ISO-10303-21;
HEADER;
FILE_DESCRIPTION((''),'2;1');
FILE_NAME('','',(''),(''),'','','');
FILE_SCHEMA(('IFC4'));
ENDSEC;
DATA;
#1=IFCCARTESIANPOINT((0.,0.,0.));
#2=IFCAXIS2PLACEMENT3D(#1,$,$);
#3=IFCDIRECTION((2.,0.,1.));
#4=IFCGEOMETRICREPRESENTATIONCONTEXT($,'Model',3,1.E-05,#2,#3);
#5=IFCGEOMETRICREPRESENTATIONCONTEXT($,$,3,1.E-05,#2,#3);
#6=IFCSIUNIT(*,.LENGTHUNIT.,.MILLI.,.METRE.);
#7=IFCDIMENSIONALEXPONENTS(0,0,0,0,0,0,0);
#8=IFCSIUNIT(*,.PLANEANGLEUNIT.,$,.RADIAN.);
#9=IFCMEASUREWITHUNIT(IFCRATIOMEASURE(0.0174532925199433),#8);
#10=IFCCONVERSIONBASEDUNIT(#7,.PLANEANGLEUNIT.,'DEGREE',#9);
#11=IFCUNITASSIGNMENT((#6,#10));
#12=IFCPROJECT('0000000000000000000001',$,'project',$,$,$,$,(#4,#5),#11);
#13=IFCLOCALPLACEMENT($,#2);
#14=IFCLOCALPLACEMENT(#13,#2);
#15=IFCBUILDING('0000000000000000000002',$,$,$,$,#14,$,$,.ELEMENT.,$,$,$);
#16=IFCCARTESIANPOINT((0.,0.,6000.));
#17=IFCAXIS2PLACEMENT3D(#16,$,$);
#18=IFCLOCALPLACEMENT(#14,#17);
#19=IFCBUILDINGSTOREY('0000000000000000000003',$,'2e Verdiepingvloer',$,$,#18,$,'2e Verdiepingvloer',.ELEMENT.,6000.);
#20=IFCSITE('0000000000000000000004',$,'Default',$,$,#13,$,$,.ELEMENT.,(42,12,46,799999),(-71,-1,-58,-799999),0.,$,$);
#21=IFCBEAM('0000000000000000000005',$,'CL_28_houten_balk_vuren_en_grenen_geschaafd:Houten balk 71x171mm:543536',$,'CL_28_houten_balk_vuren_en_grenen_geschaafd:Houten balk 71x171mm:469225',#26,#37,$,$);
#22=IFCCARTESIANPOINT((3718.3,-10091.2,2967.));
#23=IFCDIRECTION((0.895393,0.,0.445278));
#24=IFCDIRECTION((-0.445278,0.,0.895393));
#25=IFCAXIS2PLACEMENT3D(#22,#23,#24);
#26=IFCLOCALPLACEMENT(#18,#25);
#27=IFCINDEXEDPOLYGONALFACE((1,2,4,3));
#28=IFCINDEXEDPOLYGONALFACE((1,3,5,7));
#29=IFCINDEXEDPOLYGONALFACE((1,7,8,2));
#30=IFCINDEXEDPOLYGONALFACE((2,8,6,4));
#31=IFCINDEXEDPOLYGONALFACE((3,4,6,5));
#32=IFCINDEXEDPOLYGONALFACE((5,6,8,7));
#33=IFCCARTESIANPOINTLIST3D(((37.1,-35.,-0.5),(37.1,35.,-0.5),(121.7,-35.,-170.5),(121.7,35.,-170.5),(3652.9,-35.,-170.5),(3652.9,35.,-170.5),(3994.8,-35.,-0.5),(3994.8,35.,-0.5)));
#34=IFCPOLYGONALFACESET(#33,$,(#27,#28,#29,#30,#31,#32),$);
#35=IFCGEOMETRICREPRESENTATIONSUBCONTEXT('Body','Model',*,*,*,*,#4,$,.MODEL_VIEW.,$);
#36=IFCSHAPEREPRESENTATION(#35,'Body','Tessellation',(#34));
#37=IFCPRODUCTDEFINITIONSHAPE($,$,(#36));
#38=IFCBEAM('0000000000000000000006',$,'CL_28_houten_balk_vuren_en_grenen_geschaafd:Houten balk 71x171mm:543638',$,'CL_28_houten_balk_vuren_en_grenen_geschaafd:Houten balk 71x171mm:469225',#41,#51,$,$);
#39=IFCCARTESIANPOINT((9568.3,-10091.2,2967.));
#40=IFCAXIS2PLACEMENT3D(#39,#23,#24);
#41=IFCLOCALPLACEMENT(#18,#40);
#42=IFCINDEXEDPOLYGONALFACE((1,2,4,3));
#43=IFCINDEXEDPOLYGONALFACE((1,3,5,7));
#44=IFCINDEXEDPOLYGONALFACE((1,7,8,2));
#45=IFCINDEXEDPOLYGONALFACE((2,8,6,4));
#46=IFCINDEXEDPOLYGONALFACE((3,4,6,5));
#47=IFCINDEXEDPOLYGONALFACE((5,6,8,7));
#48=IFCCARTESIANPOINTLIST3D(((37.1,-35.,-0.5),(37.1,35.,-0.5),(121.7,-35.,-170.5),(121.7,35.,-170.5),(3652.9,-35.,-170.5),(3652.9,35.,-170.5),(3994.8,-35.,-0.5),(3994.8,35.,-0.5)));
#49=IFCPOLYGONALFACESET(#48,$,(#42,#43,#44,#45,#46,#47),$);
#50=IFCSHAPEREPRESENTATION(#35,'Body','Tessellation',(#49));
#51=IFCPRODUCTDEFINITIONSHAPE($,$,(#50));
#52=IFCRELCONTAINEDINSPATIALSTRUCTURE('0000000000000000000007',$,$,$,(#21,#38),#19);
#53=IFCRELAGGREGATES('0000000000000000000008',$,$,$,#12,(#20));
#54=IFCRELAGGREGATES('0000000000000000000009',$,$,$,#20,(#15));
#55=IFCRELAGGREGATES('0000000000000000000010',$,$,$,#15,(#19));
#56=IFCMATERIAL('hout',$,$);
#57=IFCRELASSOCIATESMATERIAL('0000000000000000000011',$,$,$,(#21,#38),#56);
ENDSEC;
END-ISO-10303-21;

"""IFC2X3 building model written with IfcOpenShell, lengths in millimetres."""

from ifc_helpers import new_model, entity, si_unit, converted_unit, direction, frame, frame_2d, origin, place, context, subcontext, project, spatial, rectangle, extrude, clip, halfspace, material, element, save


model = new_model("IFC2X3")

# Units and contexts
model_context = context("Model", 3, precision=1e-05, world=origin(), true_north=direction((2.0, 0.0, 1.0)))
context_of_model = context(None, 3, precision=1e-05, world=origin(), true_north=direction((2.0, 0.0, 1.0)))
body_context = subcontext(model_context, "Body", "Model", "MODEL_VIEW")
ifc_project = project(units=[si_unit("LENGTHUNIT", "METRE", prefix="MILLI"), converted_unit("PLANEANGLEUNIT", "DEGREE", entity("IfcRatioMeasure", 0.0174532925199433), si_unit("PLANEANGLEUNIT", "RADIAN"), dimensions=[0, 0, 0, 0, 0, 0, 0])], contexts=[model_context, context_of_model])

# Site, building, storey
site_placement = place(None, origin())
site = spatial("IfcSite", under=ifc_project, at=site_placement, Name="Default", CompositionType="ELEMENT", RefLatitude=(42, 12, 46, 799999), RefLongitude=(-71, -1, -58, -799999), RefElevation=0.0)
building_placement = place(site_placement, origin())
building = spatial("IfcBuilding", under=site, at=building_placement, CompositionType="ELEMENT")
storey_placement = place(building_placement, frame((0.0, 0.0, 6000.0)))
storey = spatial("IfcBuildingStorey", under=building, at=storey_placement, Name="2e Verdiepingvloer", LongName="2e Verdiepingvloer", CompositionType="ELEMENT", Elevation=6000.0)

# Beams
ifc_material_1 = material(Name="hout")
beam_1_placement = place(storey_placement, frame((3718.3, -10091.2, 2967.0), z_axis=(0.895393, 0.0, 0.445278), x_axis=(-0.445278, 0.0, 0.895393)))
element("IfcBeam", 1, at=beam_1_placement, inside=storey, material=ifc_material_1, Name="CL_28_houten_balk_vuren_en_grenen_geschaafd:Houten balk 71x171mm:543536", ObjectType="CL_28_houten_balk_vuren_en_grenen_geschaafd:Houten balk 71x171mm:469225", context=body_context, shape_type="Clipping", body=[
    clip(clip(extrude(rectangle(XDim=170.0, YDim=70.0, at=frame_2d((0.0, 0.0), x_axis=(1.0, 0.0))), frame((37.1, 0.0, -85.5), z_axis=(1.0, 0.0, 0.0), x_axis=(0.0, 0.0, -1.0)), (0.0, 0.0, 1.0), 3957.7), halfspace(frame((3651.9, 0.0, -171.0), z_axis=(0.445278, 0.0, -0.895393), x_axis=(0.0, 1.0, 0.0)), False)), halfspace(frame((-9522.9, -1.8, 19223.4), z_axis=(-0.895393, 0.0, -0.445278), x_axis=(0.445278, 0.0, -0.895393)), False)),
])
beam_2_placement = place(storey_placement, frame((9568.3, -10091.2, 2967.0), z_axis=(0.895393, 0.0, 0.445278), x_axis=(-0.445278, 0.0, 0.895393)))
element("IfcBeam", 2, at=beam_2_placement, inside=storey, material=ifc_material_1, Name="CL_28_houten_balk_vuren_en_grenen_geschaafd:Houten balk 71x171mm:543638", ObjectType="CL_28_houten_balk_vuren_en_grenen_geschaafd:Houten balk 71x171mm:469225", context=body_context, shape_type="Clipping", body=[
    clip(clip(extrude(rectangle(XDim=170.0, YDim=70.0, at=frame_2d((0.0, 0.0), x_axis=(1.0, 0.0))), frame((37.1, 0.0, -85.5), z_axis=(1.0, 0.0, 0.0), x_axis=(0.0, 0.0, -1.0)), (0.0, 0.0, 1.0), 3957.7), halfspace(frame((3651.9, 0.0, -171.0), z_axis=(0.445278, 0.0, -0.895393), x_axis=(0.0, 1.0, 0.0)), False)), halfspace(frame((-6918.0, -1.8, 13985.4), z_axis=(-0.895393, 0.0, -0.445278), x_axis=(0.445278, 0.0, -0.895393)), False)),
])

save(model, "model.ifc")
